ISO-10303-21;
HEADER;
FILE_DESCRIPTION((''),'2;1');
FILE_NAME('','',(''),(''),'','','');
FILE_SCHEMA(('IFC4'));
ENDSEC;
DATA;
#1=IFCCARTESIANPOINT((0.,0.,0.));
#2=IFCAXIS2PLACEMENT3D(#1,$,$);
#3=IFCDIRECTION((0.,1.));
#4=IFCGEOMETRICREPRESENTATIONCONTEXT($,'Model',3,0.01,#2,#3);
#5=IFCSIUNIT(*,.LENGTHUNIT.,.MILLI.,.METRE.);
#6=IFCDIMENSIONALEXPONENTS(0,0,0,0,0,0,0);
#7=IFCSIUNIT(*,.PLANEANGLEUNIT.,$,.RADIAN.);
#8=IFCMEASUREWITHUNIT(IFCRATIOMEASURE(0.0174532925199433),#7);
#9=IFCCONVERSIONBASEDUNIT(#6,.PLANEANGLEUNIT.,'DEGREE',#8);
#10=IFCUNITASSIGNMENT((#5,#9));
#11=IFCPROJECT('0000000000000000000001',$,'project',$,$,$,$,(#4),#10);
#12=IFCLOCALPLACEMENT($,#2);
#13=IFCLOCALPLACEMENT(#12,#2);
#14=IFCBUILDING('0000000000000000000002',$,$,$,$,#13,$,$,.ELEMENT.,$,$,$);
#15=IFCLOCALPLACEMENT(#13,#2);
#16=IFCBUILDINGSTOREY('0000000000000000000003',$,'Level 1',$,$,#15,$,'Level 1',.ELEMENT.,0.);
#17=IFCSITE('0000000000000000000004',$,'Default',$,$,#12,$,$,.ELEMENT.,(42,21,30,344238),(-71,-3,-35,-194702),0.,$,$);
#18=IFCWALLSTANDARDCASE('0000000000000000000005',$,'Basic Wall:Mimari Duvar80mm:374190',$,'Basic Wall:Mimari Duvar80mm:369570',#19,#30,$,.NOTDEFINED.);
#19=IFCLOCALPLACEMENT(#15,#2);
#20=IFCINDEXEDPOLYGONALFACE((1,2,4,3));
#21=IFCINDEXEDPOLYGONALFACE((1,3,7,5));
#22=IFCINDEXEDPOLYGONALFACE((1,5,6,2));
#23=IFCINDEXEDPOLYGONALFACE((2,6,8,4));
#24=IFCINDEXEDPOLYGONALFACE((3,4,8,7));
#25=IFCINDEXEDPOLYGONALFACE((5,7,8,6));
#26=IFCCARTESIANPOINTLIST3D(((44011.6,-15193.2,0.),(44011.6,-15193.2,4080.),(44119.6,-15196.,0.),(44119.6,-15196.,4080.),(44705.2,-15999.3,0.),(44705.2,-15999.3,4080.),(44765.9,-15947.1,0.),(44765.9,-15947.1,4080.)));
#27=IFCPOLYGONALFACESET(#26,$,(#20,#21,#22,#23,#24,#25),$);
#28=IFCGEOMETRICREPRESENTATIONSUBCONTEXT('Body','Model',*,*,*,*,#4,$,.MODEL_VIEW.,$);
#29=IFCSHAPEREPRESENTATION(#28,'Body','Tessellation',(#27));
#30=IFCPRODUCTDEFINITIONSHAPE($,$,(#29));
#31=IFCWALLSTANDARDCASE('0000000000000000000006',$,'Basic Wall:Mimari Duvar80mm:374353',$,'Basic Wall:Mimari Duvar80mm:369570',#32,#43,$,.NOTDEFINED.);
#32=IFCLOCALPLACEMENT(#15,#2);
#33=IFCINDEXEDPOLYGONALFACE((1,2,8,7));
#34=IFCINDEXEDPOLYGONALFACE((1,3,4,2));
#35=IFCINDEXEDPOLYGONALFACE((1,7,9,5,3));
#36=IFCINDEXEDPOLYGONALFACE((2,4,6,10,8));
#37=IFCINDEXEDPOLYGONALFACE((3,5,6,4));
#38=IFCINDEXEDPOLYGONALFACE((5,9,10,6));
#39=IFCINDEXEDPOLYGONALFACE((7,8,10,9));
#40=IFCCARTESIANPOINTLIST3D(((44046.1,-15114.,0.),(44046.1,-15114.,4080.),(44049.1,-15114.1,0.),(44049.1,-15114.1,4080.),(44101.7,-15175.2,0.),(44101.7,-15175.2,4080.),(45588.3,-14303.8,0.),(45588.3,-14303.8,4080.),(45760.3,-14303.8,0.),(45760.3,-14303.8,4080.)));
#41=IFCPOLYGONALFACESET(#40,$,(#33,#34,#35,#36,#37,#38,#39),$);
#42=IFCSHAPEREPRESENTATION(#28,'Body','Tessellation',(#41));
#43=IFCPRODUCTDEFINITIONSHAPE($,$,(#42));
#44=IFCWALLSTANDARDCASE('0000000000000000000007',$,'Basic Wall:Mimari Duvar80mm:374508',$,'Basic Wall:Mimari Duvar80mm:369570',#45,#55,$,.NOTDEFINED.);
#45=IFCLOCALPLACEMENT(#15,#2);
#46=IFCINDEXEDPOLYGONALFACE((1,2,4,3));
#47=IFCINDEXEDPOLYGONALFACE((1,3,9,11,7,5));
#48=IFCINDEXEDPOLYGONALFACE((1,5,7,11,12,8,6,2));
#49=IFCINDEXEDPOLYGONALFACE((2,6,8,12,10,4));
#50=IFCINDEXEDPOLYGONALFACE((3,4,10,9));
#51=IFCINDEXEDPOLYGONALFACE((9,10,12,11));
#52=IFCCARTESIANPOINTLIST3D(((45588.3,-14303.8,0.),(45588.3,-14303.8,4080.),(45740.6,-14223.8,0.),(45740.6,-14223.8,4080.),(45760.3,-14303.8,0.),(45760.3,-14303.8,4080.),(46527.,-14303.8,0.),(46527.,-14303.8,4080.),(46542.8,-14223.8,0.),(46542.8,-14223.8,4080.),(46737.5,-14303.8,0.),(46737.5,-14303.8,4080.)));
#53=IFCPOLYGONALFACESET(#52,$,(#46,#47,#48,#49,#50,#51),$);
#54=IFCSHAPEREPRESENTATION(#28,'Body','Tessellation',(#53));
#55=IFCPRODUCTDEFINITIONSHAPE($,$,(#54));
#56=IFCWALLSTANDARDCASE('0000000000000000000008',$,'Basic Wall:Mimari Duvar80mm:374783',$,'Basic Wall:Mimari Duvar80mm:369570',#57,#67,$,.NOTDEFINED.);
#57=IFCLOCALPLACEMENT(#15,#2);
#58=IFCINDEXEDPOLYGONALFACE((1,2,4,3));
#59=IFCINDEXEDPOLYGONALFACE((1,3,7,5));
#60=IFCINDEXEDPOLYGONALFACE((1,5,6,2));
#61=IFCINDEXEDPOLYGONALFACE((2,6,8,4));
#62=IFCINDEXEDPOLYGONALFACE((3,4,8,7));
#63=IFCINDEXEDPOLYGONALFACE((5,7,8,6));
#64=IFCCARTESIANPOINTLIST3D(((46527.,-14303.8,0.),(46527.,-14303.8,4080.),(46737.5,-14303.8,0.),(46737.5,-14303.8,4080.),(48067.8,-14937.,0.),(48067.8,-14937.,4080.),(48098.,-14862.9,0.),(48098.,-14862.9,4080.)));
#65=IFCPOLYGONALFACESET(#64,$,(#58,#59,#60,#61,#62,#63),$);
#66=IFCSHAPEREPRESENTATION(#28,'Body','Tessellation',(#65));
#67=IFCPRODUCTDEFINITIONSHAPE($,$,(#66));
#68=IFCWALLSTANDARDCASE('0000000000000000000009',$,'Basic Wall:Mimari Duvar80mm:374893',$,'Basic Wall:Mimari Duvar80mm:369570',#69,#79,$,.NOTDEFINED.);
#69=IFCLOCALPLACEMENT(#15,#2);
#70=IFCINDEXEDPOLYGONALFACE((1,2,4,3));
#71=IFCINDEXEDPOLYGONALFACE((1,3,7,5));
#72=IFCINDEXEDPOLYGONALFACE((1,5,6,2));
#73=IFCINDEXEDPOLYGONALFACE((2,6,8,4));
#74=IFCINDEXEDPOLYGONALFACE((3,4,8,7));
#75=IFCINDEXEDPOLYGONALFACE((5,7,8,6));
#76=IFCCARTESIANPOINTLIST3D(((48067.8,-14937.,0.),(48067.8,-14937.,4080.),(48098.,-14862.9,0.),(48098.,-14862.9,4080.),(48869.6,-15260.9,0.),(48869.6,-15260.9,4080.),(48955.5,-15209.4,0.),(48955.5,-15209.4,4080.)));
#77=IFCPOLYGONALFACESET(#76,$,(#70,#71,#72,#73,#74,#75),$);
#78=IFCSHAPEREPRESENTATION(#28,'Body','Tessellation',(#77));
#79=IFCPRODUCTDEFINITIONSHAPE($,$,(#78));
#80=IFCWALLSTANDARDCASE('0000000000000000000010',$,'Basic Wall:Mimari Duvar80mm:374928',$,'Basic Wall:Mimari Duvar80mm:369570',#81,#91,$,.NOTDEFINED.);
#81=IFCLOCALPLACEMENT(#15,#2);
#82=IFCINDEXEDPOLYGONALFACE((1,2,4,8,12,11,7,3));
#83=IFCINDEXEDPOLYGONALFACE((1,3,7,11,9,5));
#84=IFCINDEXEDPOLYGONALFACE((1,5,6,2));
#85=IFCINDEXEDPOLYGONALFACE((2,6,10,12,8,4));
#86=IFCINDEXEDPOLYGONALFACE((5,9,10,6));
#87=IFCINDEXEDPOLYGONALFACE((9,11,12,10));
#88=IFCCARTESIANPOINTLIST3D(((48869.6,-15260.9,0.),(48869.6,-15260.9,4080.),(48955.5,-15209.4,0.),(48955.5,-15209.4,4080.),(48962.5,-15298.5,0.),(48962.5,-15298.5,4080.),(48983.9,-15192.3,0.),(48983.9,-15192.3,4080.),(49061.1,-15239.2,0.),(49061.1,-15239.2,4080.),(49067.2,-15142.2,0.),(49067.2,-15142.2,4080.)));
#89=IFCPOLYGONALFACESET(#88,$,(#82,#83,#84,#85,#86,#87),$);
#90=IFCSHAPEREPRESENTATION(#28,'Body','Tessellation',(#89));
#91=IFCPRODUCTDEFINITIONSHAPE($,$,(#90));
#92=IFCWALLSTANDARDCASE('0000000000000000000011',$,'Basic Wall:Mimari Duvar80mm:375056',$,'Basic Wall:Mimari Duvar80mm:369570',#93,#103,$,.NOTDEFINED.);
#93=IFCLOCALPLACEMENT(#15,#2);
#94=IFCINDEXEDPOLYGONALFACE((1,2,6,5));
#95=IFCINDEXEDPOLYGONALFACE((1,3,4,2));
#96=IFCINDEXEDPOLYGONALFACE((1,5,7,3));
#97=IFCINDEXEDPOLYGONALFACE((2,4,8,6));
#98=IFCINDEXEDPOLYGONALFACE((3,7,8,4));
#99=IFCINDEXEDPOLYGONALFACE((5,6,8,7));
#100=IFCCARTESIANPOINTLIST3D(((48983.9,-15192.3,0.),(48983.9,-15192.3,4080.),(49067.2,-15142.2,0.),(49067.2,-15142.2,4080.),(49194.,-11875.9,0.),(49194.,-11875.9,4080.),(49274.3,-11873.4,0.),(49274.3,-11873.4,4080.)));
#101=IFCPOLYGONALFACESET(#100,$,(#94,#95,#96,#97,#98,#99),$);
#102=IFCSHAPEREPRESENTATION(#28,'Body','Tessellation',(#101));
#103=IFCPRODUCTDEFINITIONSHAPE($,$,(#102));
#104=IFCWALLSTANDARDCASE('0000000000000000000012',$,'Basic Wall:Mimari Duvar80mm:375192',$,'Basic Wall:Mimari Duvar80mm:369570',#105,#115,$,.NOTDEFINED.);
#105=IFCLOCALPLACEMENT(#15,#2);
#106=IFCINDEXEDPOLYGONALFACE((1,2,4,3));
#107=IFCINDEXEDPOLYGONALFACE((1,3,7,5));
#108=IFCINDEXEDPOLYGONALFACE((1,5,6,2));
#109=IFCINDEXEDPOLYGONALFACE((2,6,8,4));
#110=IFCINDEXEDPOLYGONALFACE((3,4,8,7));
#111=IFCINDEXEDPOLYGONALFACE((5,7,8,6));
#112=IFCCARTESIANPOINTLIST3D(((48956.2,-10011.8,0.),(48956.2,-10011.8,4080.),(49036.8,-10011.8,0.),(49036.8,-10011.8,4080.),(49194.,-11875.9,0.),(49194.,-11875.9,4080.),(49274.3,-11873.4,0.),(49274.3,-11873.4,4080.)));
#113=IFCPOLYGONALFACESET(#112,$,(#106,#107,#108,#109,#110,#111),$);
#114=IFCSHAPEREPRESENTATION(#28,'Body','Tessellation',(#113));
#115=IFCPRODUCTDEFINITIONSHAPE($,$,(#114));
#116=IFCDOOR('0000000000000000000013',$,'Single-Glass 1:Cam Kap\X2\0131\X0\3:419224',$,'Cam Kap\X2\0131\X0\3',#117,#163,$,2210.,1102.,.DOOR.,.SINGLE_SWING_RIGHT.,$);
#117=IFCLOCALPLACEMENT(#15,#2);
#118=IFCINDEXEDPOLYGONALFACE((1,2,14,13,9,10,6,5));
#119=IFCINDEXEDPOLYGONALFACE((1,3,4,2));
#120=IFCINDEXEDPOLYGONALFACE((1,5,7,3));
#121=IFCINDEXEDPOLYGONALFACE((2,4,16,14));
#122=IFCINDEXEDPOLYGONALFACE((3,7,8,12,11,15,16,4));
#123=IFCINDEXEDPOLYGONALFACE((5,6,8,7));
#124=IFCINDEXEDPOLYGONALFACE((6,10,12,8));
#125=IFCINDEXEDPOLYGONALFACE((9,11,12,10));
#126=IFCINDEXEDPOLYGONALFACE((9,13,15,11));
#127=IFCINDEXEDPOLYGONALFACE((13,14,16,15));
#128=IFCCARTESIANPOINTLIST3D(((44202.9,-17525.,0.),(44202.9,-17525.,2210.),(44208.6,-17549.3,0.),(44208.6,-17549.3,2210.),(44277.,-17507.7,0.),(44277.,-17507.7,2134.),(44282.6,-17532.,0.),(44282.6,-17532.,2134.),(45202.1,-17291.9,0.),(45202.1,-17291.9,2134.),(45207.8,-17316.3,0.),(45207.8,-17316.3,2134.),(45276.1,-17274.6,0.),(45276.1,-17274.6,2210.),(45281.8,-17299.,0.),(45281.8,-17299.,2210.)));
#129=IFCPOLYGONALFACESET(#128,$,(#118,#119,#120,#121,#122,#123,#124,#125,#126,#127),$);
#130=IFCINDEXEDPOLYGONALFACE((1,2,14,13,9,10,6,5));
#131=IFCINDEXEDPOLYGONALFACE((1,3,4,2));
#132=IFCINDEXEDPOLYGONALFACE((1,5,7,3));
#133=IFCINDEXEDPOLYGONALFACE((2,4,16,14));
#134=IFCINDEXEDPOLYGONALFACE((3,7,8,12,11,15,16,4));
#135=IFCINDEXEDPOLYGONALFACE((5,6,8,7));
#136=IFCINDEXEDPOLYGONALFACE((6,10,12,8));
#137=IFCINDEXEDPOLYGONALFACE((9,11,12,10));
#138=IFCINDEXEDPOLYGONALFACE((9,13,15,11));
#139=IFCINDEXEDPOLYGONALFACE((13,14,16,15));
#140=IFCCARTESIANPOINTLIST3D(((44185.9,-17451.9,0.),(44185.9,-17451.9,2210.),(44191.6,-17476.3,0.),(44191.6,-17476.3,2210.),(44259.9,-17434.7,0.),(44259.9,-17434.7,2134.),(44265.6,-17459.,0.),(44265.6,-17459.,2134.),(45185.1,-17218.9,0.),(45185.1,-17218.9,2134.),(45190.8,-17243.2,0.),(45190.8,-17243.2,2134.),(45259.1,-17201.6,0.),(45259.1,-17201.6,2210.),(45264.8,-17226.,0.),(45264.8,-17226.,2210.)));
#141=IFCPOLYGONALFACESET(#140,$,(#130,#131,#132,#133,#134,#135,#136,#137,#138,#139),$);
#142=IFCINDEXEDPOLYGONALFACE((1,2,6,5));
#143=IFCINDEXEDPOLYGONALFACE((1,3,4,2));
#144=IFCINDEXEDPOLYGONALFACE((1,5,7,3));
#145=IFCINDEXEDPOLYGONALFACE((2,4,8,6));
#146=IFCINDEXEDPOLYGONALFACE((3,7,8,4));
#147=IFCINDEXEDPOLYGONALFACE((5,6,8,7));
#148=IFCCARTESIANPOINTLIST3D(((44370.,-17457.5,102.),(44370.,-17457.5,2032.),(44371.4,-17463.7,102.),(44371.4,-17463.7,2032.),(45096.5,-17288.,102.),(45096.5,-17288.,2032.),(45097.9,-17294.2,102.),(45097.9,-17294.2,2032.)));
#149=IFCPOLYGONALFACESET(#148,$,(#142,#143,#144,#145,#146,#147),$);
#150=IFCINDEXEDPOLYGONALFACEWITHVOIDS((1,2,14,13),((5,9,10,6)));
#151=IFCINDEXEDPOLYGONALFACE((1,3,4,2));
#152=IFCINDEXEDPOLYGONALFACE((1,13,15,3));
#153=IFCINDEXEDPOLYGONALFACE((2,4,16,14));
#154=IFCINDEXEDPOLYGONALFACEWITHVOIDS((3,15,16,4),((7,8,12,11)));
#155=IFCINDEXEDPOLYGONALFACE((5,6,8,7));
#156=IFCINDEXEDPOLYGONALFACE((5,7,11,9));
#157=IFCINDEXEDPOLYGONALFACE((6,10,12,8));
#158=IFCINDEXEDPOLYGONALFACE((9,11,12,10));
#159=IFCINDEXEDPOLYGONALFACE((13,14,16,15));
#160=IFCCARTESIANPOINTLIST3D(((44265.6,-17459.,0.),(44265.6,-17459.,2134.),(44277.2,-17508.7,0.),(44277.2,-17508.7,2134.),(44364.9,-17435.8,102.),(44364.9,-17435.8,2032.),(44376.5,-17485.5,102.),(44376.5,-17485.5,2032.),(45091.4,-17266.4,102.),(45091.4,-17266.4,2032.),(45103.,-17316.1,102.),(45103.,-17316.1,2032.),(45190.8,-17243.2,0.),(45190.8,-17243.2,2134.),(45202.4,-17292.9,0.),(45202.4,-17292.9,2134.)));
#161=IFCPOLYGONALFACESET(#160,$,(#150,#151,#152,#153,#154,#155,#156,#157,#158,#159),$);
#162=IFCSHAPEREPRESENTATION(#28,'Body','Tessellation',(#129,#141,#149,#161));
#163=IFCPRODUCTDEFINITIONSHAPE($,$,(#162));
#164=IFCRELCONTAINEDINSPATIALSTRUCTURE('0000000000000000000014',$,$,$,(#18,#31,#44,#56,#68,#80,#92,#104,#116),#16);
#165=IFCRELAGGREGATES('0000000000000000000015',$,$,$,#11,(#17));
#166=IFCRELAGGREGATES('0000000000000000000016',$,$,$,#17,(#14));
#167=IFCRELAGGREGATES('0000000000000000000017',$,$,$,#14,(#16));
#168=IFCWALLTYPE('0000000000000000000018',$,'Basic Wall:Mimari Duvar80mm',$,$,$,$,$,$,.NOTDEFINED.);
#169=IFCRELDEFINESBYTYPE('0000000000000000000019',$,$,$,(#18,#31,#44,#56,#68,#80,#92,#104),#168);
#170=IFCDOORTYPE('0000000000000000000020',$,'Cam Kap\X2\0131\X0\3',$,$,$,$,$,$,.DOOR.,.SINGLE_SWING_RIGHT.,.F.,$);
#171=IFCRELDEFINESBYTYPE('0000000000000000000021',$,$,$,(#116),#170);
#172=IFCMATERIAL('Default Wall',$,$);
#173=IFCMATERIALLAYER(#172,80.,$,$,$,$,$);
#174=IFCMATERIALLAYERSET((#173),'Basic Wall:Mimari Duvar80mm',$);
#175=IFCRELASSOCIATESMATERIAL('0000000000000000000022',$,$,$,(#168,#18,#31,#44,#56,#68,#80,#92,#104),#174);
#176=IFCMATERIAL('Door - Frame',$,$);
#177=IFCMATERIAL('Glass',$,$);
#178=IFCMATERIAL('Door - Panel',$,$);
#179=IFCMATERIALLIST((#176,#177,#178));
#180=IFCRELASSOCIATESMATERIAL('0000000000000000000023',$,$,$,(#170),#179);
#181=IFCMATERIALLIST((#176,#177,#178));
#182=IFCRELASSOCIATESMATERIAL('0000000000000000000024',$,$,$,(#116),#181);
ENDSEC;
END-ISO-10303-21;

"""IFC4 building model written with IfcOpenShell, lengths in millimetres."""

from ifc_helpers import new_model, entity, si_unit, converted_unit, direction, frame, origin, origin_2d_with_axis, place, context, subcontext, project, spatial, polyline, rectangle, outline, extrude, source, transform, mapped, material, material_list, layer, layer_set, layer_usage, type_object, type_shapes, element, save


model = new_model("IFC4")

# Units and contexts
model_context = context("Model", 3, precision=0.01, world=origin(), true_north=direction((0.0, 1.0)))
body_context = subcontext(model_context, "Body", "Model", "MODEL_VIEW")
ifc_project = project(units=[si_unit("LENGTHUNIT", "METRE", prefix="MILLI"), converted_unit("PLANEANGLEUNIT", "DEGREE", entity("IfcRatioMeasure", 0.0174532925199433), si_unit("PLANEANGLEUNIT", "RADIAN"), dimensions=[0, 0, 0, 0, 0, 0, 0])], contexts=[model_context])

# Site, building, storey
site_placement = place(None, origin())
site = spatial("IfcSite", under=ifc_project, at=site_placement, Name="Default", CompositionType="ELEMENT", RefLatitude=(42, 21, 30, 344238), RefLongitude=(-71, -3, -35, -194702), RefElevation=0.0)
building_placement = place(site_placement, origin())
building = spatial("IfcBuilding", under=site, at=building_placement, CompositionType="ELEMENT")
storey_placement = place(building_placement, origin())
storey = spatial("IfcBuildingStorey", under=building, at=storey_placement, Name="Level 1", LongName="Level 1", CompositionType="ELEMENT", Elevation=0.0)

# Shared definitions
ifc_material_1 = material(Name="Glass")

# Walls
ifc_material_2 = material(Name="Default Wall")
ifc_layer = layer(ifc_material_2, 80.0)
ifc_layer_set = layer_set([ifc_layer], Name="Basic Wall:Mimari Duvar80mm")
ifc_layer_usage_1 = layer_usage(ifc_layer_set, "AXIS2", "NEGATIVE", 40.0)
wall_type = type_object("IfcWallType", Name="Basic Wall:Mimari Duvar80mm", PredefinedType="NOTDEFINED", material=ifc_layer_set)
wall_1_placement = place(storey_placement, frame((44041.9, -15167.1, 0.0), z_axis=(0.0, 0.0, 1.0), x_axis=(0.652245, -0.758008, 0.0)))
element("IfcWallStandardCase", 1, at=wall_1_placement, inside=storey, type_object=wall_type, material=ifc_layer_usage_1, Name="Basic Wall:Mimari Duvar80mm:374190", ObjectType="Basic Wall:Mimari Duvar80mm:369570", PredefinedType="NOTDEFINED", context=body_context, shape_type="SweptSolid", body=[
    extrude(outline(polyline([(1063.5, -40.0), (1063.5, 40.0), (72.6, 40.0), (0.0, -40.0), (1063.5, -40.0)])), origin(), (0.0, 0.0, 1.0), 4080.0),
])
ifc_layer_usage_2 = layer_usage(ifc_layer_set, "AXIS2", "NEGATIVE", 40.0)
wall_2_placement = place(storey_placement, frame((44064.7, -15149.5, 0.0), z_axis=(0.0, 0.0, 1.0), x_axis=(0.885263, 0.465091, 0.0)))
element("IfcWallStandardCase", 2, at=wall_2_placement, inside=storey, type_object=wall_type, material=ifc_layer_usage_2, Name="Basic Wall:Mimari Duvar80mm:374353", ObjectType="Basic Wall:Mimari Duvar80mm:369570", PredefinedType="NOTDEFINED", context=body_context, shape_type="SweptSolid", body=[
    extrude(outline(polyline([(1894.4, -40.0), (1742.1, 40.0), (0.0, 40.0), (2.6, 38.5), (20.8, -40.0), (1894.4, -40.0)])), origin(), (0.0, 0.0, 1.0), 4080.0),
])
ifc_layer_usage_3 = layer_usage(ifc_layer_set, "AXIS2", "NEGATIVE", 40.0)
wall_3_placement = place(storey_placement, frame((45588.3, -14263.8, 0.0)))
element("IfcWallStandardCase", 3, at=wall_3_placement, inside=storey, type_object=wall_type, material=ifc_layer_usage_3, Name="Basic Wall:Mimari Duvar80mm:374508", ObjectType="Basic Wall:Mimari Duvar80mm:369570", PredefinedType="NOTDEFINED", context=body_context, shape_type="SweptSolid", body=[
    extrude(outline(polyline([(1149.1, -40.0), (954.5, 40.0), (152.3, 40.0), (0.0, -40.0), (172.0, -40.0), (938.7, -40.0), (1149.1, -40.0)])), origin(), (0.0, 0.0, 1.0), 4080.0),
])
ifc_layer_usage_4 = layer_usage(ifc_layer_set, "AXIS2", "NEGATIVE", 40.0)
wall_4_placement = place(storey_placement, frame((46542.2, -14266.8, 0.0), z_axis=(0.0, 0.0, 1.0), x_axis=(0.924944, -0.380102, 0.0)))
element("IfcWallStandardCase", 4, at=wall_4_placement, inside=storey, type_object=wall_type, material=ifc_layer_usage_4, Name="Basic Wall:Mimari Duvar80mm:374783", ObjectType="Basic Wall:Mimari Duvar80mm:369570", PredefinedType="NOTDEFINED", context=body_context, shape_type="SweptSolid", body=[
    extrude(outline(polyline([(1665.8, -40.0), (1665.6, 40.0), (194.7, 40.0), (0.0, -40.0), (1665.8, -40.0)])), origin(), (0.0, 0.0, 1.0), 4080.0),
])
ifc_layer_usage_5 = layer_usage(ifc_layer_set, "AXIS2", "NEGATIVE", 40.0)
wall_5_placement = place(storey_placement, frame((48082.8, -14899.9, 0.0), z_axis=(0.0, 0.0, 1.0), x_axis=(0.927184, -0.374607, 0.0)))
element("IfcWallStandardCase", 5, at=wall_5_placement, inside=storey, type_object=wall_type, material=ifc_layer_usage_5, Name="Basic Wall:Mimari Duvar80mm:374893", ObjectType="Basic Wall:Mimari Duvar80mm:369570", PredefinedType="NOTDEFINED", context=body_context, shape_type="SweptSolid", body=[
    extrude(outline(polyline([(864.8, -40.0), (925.1, 40.0), (0.2, 40.0), (0.0, -40.0), (864.8, -40.0)])), origin(), (0.0, 0.0, 1.0), 4080.0),
])
ifc_layer_usage_6 = layer_usage(ifc_layer_set, "AXIS2", "NEGATIVE", 40.0)
wall_6_placement = place(storey_placement, frame((48890.3, -15295.2, 0.0), z_axis=(0.0, 0.0, 1.0), x_axis=(0.857167, 0.515038, 0.0)))
element("IfcWallStandardCase", 6, at=wall_6_placement, inside=storey, type_object=wall_type, material=ifc_layer_usage_6, Name="Basic Wall:Mimari Duvar80mm:374928", ObjectType="Basic Wall:Mimari Duvar80mm:369570", PredefinedType="NOTDEFINED", context=body_context, shape_type="SweptSolid", body=[
    extrude(outline(polyline([(175.3, -40.0), (230.5, 40.0), (133.3, 40.0), (100.2, 40.0), (0.0, 40.0), (60.3, -40.0), (175.3, -40.0)])), origin(), (0.0, 0.0, 1.0), 4080.0),
])
ifc_layer_usage_7 = layer_usage(ifc_layer_set, "AXIS2", "NEGATIVE", 40.0)
wall_7_placement = place(storey_placement, frame((49023.8, -15194.8, 0.0), z_axis=(0.0, 0.0, 1.0), x_axis=(0.063229, 0.997999, 0.0)))
element("IfcWallStandardCase", 7, at=wall_7_placement, inside=storey, type_object=wall_type, material=ifc_layer_usage_7, Name="Basic Wall:Mimari Duvar80mm:375056", ObjectType="Basic Wall:Mimari Duvar80mm:369570", PredefinedType="NOTDEFINED", context=body_context, shape_type="SweptSolid", body=[
    extrude(outline(polyline([(3330.6, -40.0), (3323.0, 40.0), (0.0, 40.0), (55.2, -40.0), (3330.6, -40.0)])), origin(), (0.0, 0.0, 1.0), 4080.0),
])
ifc_layer_usage_8 = layer_usage(ifc_layer_set, "AXIS2", "NEGATIVE", 40.0)
wall_8_placement = place(storey_placement, frame((49234.7, -11878.4, 0.0), z_axis=(0.0, 0.0, 1.0), x_axis=(-0.126557, 0.991959, 0.0)))
element("IfcWallStandardCase", 8, at=wall_8_placement, inside=storey, type_object=wall_type, material=ifc_layer_usage_8, Name="Basic Wall:Mimari Duvar80mm:375192", ObjectType="Basic Wall:Mimari Duvar80mm:369570", PredefinedType="NOTDEFINED", context=body_context, shape_type="SweptSolid", body=[
    extrude(outline(polyline([(1876.7, -40.0), (1886.9, 40.0), (7.6, 40.0), (0.0, -40.0), (1876.7, -40.0)])), origin(), (0.0, 0.0, 1.0), 4080.0),
])

# Door
ifc_material_3 = material(Name="Door - Frame")
ifc_material_4 = material(Name="Door - Panel")
ifc_material_list_1 = material_list([ifc_material_3, ifc_material_1, ifc_material_4])
ifc_material_list_2 = material_list([ifc_material_3, ifc_material_1, ifc_material_4])
door_type = type_object("IfcDoorType", Name="Cam Kapı3", OperationType="SINGLE_SWING_RIGHT", ParameterTakesPrecedence=False, PredefinedType="DOOR", material=ifc_material_list_2)
shared_shape_1 = source(origin(), body_context, "Body", "SweptSolid", [
    extrude(outline(polyline([(-475.0, -1048.0), (-475.0, 1086.0), (-551.0, 1086.0), (-551.0, -1124.0), (551.0, -1124.0), (551.0, 1086.0), (475.0, 1086.0), (475.0, -1048.0), (-475.0, -1048.0)])), frame((475.0, -25.0, 1086.0), z_axis=(0.0, -1.0, 0.0), x_axis=(-1.0, 0.0, 0.0)), (0.0, 0.0, -1.0), 25.0),
    extrude(outline(polyline([(-475.0, -1048.0), (-475.0, 1086.0), (-551.0, 1086.0), (-551.0, -1124.0), (551.0, -1124.0), (551.0, 1086.0), (475.0, 1086.0), (475.0, -1048.0), (-475.0, -1048.0)])), frame((475.0, 50.0, 1086.0), z_axis=(0.0, -1.0, 0.0), x_axis=(-1.0, 0.0, 0.0)), (0.0, 0.0, -1.0), 25.0),
    extrude(rectangle(XDim=6.3, YDim=746.0, at=origin_2d_with_axis()), frame((475.0, 24.6, 102.0), z_axis=(0.0, 0.0, 1.0), x_axis=(0.0, 1.0, 0.0)), (0.0, 0.0, 1.0), 1930.0),
    extrude(outline(polyline([(-1067.0, -475.0), (1067.0, -475.0), (1067.0, 475.0), (-1067.0, 475.0), (-1067.0, -475.0)]), holes=[polyline([(-965.0, 373.0), (965.0, 373.0), (965.0, -373.0), (-965.0, -373.0), (-965.0, 373.0)])]), frame((475.0, -1.0, 1067.0), z_axis=(0.0, 1.0, 0.0), x_axis=(0.0, 0.0, -1.0)), (0.0, 0.0, 1.0), 51.0),
])
type_shapes(door_type, [shared_shape_1])
door_placement = place(storey_placement, frame((44277.0, -17507.7, 0.0), z_axis=(0.0, 0.0, 1.0), x_axis=(0.973861, 0.227145, 0.0)))
element("IfcDoor", 9, at=door_placement, inside=storey, type_object=door_type, material=ifc_material_list_1, Name="Single-Glass 1:Cam Kapı3:419224", ObjectType="Cam Kapı3", OperationType="SINGLE_SWING_RIGHT", OverallHeight=2210.0, OverallWidth=1102.0, PredefinedType="DOOR", context=body_context, shape_type="MappedRepresentation", body=[
    mapped(shared_shape_1, transform((0.0, 0.0, 0.0), scale=1.0)),
])

save(model, "model.ifc")
